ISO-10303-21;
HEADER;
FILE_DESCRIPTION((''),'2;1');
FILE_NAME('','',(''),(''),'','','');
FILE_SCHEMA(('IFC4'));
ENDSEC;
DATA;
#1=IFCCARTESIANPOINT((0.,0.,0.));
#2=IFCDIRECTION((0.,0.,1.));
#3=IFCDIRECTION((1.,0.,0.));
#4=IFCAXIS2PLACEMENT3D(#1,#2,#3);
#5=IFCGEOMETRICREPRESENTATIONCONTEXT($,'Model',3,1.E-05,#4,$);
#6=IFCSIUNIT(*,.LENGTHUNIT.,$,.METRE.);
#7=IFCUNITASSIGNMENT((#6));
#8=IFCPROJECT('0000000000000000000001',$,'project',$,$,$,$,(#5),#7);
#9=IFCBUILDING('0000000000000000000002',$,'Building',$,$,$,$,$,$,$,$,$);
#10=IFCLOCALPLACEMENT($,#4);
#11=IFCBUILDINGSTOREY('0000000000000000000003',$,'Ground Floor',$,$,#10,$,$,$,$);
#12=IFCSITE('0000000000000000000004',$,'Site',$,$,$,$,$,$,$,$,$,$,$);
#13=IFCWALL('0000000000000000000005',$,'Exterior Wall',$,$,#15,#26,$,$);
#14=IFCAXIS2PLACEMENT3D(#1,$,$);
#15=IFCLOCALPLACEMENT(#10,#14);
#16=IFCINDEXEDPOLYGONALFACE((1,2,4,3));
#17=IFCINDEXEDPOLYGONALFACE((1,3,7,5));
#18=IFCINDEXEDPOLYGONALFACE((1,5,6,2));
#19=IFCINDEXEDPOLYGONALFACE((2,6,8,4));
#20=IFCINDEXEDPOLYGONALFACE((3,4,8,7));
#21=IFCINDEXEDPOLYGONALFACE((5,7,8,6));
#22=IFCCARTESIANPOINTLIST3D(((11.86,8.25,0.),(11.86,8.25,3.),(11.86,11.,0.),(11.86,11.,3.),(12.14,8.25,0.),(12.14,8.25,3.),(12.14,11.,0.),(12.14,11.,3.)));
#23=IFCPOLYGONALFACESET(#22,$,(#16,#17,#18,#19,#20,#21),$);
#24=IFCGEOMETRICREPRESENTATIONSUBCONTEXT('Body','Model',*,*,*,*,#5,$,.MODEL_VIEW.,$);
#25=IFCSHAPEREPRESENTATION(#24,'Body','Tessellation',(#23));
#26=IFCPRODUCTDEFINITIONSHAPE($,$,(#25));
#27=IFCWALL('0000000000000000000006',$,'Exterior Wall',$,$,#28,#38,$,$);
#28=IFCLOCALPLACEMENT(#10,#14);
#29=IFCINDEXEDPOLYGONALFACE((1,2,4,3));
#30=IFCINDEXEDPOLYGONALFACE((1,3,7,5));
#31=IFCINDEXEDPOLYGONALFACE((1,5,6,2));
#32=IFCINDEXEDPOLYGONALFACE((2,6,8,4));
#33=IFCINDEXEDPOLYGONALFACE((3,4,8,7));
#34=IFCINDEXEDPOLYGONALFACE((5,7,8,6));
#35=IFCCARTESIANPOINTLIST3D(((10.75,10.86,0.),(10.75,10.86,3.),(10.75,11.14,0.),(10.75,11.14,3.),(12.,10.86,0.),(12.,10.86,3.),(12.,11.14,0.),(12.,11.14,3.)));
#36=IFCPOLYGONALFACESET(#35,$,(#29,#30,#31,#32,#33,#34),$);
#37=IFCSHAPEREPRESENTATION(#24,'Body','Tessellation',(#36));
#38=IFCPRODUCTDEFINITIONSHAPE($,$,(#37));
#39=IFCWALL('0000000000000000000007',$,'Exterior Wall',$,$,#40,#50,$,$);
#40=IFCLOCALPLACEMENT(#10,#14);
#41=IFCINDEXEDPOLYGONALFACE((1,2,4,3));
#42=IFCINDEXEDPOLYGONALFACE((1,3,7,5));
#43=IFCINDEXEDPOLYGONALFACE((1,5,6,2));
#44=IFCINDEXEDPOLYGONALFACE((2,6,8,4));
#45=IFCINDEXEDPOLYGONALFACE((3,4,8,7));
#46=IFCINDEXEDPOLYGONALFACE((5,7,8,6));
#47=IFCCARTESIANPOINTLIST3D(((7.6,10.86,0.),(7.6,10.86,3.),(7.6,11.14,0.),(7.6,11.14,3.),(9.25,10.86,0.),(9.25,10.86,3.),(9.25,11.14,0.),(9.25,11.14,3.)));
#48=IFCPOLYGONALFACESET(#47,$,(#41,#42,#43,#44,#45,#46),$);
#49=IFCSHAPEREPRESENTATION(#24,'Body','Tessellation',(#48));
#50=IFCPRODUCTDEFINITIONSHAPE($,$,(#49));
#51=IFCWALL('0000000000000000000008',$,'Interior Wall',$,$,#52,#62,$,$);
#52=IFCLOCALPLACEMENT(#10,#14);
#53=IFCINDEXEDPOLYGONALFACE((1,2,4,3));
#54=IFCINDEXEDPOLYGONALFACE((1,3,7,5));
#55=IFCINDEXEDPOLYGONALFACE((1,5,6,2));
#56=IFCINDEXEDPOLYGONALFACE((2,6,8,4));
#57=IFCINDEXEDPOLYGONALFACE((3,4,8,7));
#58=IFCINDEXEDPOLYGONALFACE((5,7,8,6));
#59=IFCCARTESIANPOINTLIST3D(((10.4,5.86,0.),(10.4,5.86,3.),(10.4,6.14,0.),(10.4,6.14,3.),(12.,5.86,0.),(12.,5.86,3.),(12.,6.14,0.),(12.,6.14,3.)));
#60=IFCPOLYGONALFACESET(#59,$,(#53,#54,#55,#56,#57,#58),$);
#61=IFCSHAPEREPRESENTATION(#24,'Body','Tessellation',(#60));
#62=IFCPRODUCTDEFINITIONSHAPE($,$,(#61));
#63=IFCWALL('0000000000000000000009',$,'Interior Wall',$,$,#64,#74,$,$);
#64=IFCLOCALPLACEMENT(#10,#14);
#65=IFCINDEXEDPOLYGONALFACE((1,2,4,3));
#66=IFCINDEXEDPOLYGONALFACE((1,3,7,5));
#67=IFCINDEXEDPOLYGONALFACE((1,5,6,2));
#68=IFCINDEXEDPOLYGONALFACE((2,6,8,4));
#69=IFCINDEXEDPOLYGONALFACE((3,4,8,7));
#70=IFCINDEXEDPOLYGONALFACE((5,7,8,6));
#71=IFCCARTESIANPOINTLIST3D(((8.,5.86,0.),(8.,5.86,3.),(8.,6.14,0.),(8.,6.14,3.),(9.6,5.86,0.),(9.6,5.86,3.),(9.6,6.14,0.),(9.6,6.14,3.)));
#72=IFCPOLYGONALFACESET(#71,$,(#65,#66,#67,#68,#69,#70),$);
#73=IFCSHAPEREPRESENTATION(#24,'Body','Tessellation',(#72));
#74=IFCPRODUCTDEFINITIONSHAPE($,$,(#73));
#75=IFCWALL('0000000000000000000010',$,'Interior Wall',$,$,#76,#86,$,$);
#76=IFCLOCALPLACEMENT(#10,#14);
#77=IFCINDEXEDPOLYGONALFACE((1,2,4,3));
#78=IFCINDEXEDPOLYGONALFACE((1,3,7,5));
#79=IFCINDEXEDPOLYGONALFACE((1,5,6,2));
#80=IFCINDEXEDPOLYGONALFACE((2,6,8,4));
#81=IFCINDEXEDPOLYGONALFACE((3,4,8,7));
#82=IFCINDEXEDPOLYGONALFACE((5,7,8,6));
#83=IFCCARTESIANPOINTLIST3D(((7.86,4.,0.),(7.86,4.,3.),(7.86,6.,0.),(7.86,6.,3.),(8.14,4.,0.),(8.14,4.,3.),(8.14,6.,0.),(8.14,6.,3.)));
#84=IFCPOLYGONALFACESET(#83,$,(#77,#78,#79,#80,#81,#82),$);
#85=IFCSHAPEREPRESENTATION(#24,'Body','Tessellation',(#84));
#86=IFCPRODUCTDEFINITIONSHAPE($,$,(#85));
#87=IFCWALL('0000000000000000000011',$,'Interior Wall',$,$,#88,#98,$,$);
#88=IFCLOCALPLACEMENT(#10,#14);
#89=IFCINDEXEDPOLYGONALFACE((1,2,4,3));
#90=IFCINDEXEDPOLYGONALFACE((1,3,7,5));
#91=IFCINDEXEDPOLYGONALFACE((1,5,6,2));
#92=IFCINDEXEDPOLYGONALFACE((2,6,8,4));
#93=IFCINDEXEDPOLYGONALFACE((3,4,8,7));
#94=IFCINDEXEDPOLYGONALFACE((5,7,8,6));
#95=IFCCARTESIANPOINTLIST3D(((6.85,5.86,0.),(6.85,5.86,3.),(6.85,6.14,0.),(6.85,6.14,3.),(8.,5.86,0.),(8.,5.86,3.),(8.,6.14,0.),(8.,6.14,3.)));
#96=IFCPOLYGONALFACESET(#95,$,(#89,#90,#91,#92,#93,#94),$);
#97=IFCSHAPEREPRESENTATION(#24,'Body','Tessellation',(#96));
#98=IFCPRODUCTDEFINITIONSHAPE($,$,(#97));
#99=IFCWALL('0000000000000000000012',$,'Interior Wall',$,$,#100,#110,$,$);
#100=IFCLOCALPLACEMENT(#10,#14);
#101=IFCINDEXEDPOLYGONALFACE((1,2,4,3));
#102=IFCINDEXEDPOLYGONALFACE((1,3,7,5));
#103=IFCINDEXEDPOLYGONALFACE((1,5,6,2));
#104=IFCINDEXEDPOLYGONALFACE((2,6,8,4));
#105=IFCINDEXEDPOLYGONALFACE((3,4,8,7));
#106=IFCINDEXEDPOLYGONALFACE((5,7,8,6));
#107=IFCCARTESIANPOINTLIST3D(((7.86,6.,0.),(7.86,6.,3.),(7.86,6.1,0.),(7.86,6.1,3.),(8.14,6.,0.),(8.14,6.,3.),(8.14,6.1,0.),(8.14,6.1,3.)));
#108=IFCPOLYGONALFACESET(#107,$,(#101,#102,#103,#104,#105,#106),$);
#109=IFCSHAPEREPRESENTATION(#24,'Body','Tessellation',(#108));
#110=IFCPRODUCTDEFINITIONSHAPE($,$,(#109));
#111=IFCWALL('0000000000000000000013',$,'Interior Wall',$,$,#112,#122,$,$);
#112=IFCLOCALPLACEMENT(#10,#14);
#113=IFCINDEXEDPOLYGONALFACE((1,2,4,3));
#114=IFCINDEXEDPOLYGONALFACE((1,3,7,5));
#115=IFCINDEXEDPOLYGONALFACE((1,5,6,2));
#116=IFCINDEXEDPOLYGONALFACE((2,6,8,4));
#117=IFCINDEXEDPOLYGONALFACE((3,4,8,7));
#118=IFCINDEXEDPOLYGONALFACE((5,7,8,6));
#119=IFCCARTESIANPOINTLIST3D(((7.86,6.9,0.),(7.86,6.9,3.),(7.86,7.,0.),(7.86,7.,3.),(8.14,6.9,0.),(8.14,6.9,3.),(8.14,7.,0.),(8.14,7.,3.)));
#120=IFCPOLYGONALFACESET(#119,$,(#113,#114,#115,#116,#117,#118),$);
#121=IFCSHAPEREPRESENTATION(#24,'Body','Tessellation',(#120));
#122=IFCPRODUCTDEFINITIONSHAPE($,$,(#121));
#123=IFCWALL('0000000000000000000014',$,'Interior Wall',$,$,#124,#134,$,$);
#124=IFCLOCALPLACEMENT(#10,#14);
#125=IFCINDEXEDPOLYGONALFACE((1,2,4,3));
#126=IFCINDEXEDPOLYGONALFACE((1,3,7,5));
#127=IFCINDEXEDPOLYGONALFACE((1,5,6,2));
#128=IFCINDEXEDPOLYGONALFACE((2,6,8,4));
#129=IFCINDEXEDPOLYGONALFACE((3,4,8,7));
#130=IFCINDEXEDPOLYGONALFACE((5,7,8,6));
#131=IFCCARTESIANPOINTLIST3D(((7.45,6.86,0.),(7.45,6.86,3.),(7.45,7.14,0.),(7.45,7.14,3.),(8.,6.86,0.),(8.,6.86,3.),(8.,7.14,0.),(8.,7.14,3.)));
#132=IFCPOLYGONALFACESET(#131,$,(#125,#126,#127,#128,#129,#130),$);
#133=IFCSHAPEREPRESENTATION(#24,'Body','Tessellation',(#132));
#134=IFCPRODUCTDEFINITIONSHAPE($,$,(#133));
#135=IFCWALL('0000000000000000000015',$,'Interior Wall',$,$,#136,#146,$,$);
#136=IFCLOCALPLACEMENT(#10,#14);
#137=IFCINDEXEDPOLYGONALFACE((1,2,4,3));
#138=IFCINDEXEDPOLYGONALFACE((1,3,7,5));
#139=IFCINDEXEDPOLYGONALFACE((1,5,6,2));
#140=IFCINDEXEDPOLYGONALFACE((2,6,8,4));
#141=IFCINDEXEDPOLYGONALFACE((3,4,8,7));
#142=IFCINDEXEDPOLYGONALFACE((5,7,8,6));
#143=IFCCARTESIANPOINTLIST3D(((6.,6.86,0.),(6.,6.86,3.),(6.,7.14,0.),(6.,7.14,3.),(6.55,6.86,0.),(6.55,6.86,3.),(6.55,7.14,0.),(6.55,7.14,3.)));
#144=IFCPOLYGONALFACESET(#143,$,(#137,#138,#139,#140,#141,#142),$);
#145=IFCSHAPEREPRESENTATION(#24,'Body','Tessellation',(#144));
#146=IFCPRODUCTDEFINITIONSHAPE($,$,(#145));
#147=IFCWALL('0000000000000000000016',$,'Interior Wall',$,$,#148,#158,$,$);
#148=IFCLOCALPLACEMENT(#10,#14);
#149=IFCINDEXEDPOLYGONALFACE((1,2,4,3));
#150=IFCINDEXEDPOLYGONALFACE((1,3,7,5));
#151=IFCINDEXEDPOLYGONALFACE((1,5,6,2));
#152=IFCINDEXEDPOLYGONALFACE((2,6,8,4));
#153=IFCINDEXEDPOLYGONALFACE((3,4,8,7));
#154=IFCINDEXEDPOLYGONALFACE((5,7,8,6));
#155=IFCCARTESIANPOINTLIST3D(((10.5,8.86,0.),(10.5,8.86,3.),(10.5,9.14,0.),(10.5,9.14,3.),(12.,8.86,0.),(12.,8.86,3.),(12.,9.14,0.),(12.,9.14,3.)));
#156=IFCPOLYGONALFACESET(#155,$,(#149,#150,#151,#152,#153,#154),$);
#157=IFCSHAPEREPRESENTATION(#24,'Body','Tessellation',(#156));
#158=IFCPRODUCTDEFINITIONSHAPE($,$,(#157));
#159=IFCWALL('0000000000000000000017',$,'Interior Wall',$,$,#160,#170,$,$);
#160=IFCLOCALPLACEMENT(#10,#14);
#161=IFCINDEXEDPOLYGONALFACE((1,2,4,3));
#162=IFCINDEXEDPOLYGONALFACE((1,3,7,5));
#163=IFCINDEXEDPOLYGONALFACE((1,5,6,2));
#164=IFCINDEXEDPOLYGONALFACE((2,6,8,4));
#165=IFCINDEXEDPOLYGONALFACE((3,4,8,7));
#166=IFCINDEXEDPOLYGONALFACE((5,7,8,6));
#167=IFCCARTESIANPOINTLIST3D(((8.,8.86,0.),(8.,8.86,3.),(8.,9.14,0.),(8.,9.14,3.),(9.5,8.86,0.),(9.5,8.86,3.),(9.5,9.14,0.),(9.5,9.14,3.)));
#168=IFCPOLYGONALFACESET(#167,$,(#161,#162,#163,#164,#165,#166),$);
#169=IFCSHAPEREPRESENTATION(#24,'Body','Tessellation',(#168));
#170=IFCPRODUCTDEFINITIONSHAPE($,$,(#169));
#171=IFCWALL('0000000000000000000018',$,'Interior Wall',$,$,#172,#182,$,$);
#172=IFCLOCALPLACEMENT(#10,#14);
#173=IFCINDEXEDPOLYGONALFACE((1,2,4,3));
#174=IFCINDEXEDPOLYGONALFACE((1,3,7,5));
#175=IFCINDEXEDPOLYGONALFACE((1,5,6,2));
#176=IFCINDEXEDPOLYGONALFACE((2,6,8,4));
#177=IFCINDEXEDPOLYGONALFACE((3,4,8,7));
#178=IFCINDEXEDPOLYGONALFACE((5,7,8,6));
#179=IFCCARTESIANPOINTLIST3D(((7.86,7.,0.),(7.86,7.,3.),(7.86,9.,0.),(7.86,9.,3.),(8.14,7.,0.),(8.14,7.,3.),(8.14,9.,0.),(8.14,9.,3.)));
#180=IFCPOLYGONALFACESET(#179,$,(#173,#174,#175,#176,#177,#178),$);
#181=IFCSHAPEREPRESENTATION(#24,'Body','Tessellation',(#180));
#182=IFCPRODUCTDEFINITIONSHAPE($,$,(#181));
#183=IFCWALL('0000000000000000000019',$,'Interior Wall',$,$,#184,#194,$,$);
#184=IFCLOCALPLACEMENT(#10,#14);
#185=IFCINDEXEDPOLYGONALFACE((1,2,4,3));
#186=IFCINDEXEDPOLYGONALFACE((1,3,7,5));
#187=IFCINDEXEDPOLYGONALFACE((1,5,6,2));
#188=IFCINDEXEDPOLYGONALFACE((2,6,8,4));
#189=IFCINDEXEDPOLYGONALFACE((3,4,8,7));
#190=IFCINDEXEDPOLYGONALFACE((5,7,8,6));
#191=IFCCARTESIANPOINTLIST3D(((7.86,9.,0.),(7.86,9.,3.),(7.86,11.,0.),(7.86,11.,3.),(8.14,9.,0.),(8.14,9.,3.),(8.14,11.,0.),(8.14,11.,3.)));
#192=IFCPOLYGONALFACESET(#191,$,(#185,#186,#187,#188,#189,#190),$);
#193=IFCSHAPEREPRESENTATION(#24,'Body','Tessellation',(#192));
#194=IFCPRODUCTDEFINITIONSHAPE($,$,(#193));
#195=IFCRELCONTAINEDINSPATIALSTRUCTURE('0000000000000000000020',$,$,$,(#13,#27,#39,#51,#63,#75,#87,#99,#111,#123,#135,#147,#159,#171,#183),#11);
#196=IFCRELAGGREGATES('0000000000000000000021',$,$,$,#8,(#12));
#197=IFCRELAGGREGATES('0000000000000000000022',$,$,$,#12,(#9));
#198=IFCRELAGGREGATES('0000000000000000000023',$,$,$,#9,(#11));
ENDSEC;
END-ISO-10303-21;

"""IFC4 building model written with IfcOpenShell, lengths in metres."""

from ifc_helpers import new_model, si_unit, frame, origin_with_axes, place, context, subcontext, project, spatial, indexed_curve, outline, extrude, element, save


model = new_model("IFC4")

# Units and contexts
model_context = context("Model", 3, precision=1e-05, world=origin_with_axes())
body_context = subcontext(model_context, "Body", "Model", "MODEL_VIEW")
ifc_project = project(units=[si_unit("LENGTHUNIT", "METRE")], contexts=[model_context])

# Site, building, storey
site = spatial("IfcSite", under=ifc_project, Name="Site")
building = spatial("IfcBuilding", under=site, Name="Building")
storey_placement = place(None, origin_with_axes())
storey = spatial("IfcBuildingStorey", under=building, at=storey_placement, Name="Ground Floor")

# Walls
wall_1_placement = place(storey_placement, frame((12.0, 8.25, 0.0), z_axis=(0.0, 0.0, 1.0), x_axis=(0.0, 1.0, 0.0)))
element("IfcWall", 1, at=wall_1_placement, inside=storey, Name="Exterior Wall", context=body_context, shape_type="SweptSolid", body=[
    extrude(outline(indexed_curve([(0.0, 0.0), (0.0, 0.28), (2.75, 0.28), (2.75, 0.0), (0.0, 0.0)], self_intersect=False)), frame((0.0, -0.14, 0.0), z_axis=(0.0, 0.0, 1.0), x_axis=(1.0, 0.0, 0.0)), (0.0, 0.0, 1.0), 3.0),
])
wall_2_placement = place(storey_placement, frame((12.0, 11.0, 0.0), z_axis=(0.0, 0.0, 1.0), x_axis=(-1.0, 0.0, 0.0)))
element("IfcWall", 2, at=wall_2_placement, inside=storey, Name="Exterior Wall", context=body_context, shape_type="SweptSolid", body=[
    extrude(outline(indexed_curve([(0.0, 0.0), (0.0, 0.28), (1.25, 0.28), (1.25, 0.0), (0.0, 0.0)], self_intersect=False)), frame((0.0, -0.14, 0.0), z_axis=(0.0, 0.0, 1.0), x_axis=(1.0, 0.0, 0.0)), (0.0, 0.0, 1.0), 3.0),
])
wall_3_placement = place(storey_placement, frame((9.25, 11.0, 0.0), z_axis=(0.0, 0.0, 1.0), x_axis=(-1.0, 0.0, 0.0)))
element("IfcWall", 3, at=wall_3_placement, inside=storey, Name="Exterior Wall", context=body_context, shape_type="SweptSolid", body=[
    extrude(outline(indexed_curve([(0.0, 0.0), (0.0, 0.28), (1.65, 0.28), (1.65, 0.0), (0.0, 0.0)], self_intersect=False)), frame((0.0, -0.14, 0.0), z_axis=(0.0, 0.0, 1.0), x_axis=(1.0, 0.0, 0.0)), (0.0, 0.0, 1.0), 3.0),
])
for number, where, z_axis, x_axis, name in (
    (4, (12.0, 6.0, 0.0), (0.0, 0.0, 1.0), (-1.0, 0.0, 0.0), "Interior Wall"),
    (5, (9.6, 6.0, 0.0), (0.0, 0.0, 1.0), (-1.0, 0.0, 0.0), "Interior Wall"),
):
    element("IfcWall", number, at=place(storey_placement, frame(where, z_axis=z_axis, x_axis=x_axis)), inside=storey, Name=name, context=body_context, shape_type="SweptSolid", body=[
        extrude(outline(indexed_curve([(0.0, 0.0), (0.0, 0.28), (1.6, 0.28), (1.6, 0.0), (0.0, 0.0)], self_intersect=False)), frame((0.0, -0.14, 0.0), z_axis=(0.0, 0.0, 1.0), x_axis=(1.0, 0.0, 0.0)), (0.0, 0.0, 1.0), 3.0),
    ])
wall_4_placement = place(storey_placement, frame((8.0, 6.0, 0.0), z_axis=(0.0, 0.0, 1.0), x_axis=(0.0, -1.0, 0.0)))
element("IfcWall", 6, at=wall_4_placement, inside=storey, Name="Interior Wall", context=body_context, shape_type="SweptSolid", body=[
    extrude(outline(indexed_curve([(0.0, 0.0), (0.0, 0.28), (2.0, 0.28), (2.0, 0.0), (0.0, 0.0)], self_intersect=False)), frame((0.0, -0.14, 0.0), z_axis=(0.0, 0.0, 1.0), x_axis=(1.0, 0.0, 0.0)), (0.0, 0.0, 1.0), 3.0),
])
wall_5_placement = place(storey_placement, frame((8.0, 6.0, 0.0), z_axis=(0.0, 0.0, 1.0), x_axis=(-1.0, 0.0, 0.0)))
element("IfcWall", 7, at=wall_5_placement, inside=storey, Name="Interior Wall", context=body_context, shape_type="SweptSolid", body=[
    extrude(outline(indexed_curve([(0.0, 0.0), (0.0, 0.28), (1.15, 0.28), (1.15, 0.0), (0.0, 0.0)], self_intersect=False)), frame((0.0, -0.14, 0.0), z_axis=(0.0, 0.0, 1.0), x_axis=(1.0, 0.0, 0.0)), (0.0, 0.0, 1.0), 3.0),
])
for number, where, z_axis, x_axis, name in (
    (8, (8.0, 6.0, 0.0), (0.0, 0.0, 1.0), (0.0, 1.0, 0.0), "Interior Wall"),
    (9, (8.0, 6.9, 0.0), (0.0, 0.0, 1.0), (0.0, 1.0, 0.0), "Interior Wall"),
):
    element("IfcWall", number, at=place(storey_placement, frame(where, z_axis=z_axis, x_axis=x_axis)), inside=storey, Name=name, context=body_context, shape_type="SweptSolid", body=[
        extrude(outline(indexed_curve([(0.0, 0.0), (0.0, 0.28), (0.1, 0.28), (0.1, 0.0), (0.0, 0.0)], self_intersect=False)), frame((0.0, -0.14, 0.0), z_axis=(0.0, 0.0, 1.0), x_axis=(1.0, 0.0, 0.0)), (0.0, 0.0, 1.0), 3.0),
    ])
for number, where, z_axis, x_axis, name in (
    (10, (8.0, 7.0, 0.0), (0.0, 0.0, 1.0), (-1.0, 0.0, 0.0), "Interior Wall"),
    (11, (6.55, 7.0, 0.0), (0.0, 0.0, 1.0), (-1.0, 0.0, 0.0), "Interior Wall"),
):
    element("IfcWall", number, at=place(storey_placement, frame(where, z_axis=z_axis, x_axis=x_axis)), inside=storey, Name=name, context=body_context, shape_type="SweptSolid", body=[
        extrude(outline(indexed_curve([(0.0, 0.0), (0.0, 0.28), (0.55, 0.28), (0.55, 0.0), (0.0, 0.0)], self_intersect=False)), frame((0.0, -0.14, 0.0), z_axis=(0.0, 0.0, 1.0), x_axis=(1.0, 0.0, 0.0)), (0.0, 0.0, 1.0), 3.0),
    ])
for number, where, z_axis, x_axis, name in (
    (12, (12.0, 9.0, 0.0), (0.0, 0.0, 1.0), (-1.0, 0.0, 0.0), "Interior Wall"),
    (13, (9.5, 9.0, 0.0), (0.0, 0.0, 1.0), (-1.0, 0.0, 0.0), "Interior Wall"),
):
    element("IfcWall", number, at=place(storey_placement, frame(where, z_axis=z_axis, x_axis=x_axis)), inside=storey, Name=name, context=body_context, shape_type="SweptSolid", body=[
        extrude(outline(indexed_curve([(0.0, 0.0), (0.0, 0.28), (1.5, 0.28), (1.5, 0.0), (0.0, 0.0)], self_intersect=False)), frame((0.0, -0.14, 0.0), z_axis=(0.0, 0.0, 1.0), x_axis=(1.0, 0.0, 0.0)), (0.0, 0.0, 1.0), 3.0),
    ])
for number, where, z_axis, x_axis, name in (
    (14, (8.0, 9.0, 0.0), (0.0, 0.0, 1.0), (0.0, -1.0, 0.0), "Interior Wall"),
    (15, (8.0, 9.0, 0.0), (0.0, 0.0, 1.0), (0.0, 1.0, 0.0), "Interior Wall"),
):
    element("IfcWall", number, at=place(storey_placement, frame(where, z_axis=z_axis, x_axis=x_axis)), inside=storey, Name=name, context=body_context, shape_type="SweptSolid", body=[
        extrude(outline(indexed_curve([(0.0, 0.0), (0.0, 0.28), (2.0, 0.28), (2.0, 0.0), (0.0, 0.0)], self_intersect=False)), frame((0.0, -0.14, 0.0), z_axis=(0.0, 0.0, 1.0), x_axis=(1.0, 0.0, 0.0)), (0.0, 0.0, 1.0), 3.0),
    ])

save(model, "model.ifc")
